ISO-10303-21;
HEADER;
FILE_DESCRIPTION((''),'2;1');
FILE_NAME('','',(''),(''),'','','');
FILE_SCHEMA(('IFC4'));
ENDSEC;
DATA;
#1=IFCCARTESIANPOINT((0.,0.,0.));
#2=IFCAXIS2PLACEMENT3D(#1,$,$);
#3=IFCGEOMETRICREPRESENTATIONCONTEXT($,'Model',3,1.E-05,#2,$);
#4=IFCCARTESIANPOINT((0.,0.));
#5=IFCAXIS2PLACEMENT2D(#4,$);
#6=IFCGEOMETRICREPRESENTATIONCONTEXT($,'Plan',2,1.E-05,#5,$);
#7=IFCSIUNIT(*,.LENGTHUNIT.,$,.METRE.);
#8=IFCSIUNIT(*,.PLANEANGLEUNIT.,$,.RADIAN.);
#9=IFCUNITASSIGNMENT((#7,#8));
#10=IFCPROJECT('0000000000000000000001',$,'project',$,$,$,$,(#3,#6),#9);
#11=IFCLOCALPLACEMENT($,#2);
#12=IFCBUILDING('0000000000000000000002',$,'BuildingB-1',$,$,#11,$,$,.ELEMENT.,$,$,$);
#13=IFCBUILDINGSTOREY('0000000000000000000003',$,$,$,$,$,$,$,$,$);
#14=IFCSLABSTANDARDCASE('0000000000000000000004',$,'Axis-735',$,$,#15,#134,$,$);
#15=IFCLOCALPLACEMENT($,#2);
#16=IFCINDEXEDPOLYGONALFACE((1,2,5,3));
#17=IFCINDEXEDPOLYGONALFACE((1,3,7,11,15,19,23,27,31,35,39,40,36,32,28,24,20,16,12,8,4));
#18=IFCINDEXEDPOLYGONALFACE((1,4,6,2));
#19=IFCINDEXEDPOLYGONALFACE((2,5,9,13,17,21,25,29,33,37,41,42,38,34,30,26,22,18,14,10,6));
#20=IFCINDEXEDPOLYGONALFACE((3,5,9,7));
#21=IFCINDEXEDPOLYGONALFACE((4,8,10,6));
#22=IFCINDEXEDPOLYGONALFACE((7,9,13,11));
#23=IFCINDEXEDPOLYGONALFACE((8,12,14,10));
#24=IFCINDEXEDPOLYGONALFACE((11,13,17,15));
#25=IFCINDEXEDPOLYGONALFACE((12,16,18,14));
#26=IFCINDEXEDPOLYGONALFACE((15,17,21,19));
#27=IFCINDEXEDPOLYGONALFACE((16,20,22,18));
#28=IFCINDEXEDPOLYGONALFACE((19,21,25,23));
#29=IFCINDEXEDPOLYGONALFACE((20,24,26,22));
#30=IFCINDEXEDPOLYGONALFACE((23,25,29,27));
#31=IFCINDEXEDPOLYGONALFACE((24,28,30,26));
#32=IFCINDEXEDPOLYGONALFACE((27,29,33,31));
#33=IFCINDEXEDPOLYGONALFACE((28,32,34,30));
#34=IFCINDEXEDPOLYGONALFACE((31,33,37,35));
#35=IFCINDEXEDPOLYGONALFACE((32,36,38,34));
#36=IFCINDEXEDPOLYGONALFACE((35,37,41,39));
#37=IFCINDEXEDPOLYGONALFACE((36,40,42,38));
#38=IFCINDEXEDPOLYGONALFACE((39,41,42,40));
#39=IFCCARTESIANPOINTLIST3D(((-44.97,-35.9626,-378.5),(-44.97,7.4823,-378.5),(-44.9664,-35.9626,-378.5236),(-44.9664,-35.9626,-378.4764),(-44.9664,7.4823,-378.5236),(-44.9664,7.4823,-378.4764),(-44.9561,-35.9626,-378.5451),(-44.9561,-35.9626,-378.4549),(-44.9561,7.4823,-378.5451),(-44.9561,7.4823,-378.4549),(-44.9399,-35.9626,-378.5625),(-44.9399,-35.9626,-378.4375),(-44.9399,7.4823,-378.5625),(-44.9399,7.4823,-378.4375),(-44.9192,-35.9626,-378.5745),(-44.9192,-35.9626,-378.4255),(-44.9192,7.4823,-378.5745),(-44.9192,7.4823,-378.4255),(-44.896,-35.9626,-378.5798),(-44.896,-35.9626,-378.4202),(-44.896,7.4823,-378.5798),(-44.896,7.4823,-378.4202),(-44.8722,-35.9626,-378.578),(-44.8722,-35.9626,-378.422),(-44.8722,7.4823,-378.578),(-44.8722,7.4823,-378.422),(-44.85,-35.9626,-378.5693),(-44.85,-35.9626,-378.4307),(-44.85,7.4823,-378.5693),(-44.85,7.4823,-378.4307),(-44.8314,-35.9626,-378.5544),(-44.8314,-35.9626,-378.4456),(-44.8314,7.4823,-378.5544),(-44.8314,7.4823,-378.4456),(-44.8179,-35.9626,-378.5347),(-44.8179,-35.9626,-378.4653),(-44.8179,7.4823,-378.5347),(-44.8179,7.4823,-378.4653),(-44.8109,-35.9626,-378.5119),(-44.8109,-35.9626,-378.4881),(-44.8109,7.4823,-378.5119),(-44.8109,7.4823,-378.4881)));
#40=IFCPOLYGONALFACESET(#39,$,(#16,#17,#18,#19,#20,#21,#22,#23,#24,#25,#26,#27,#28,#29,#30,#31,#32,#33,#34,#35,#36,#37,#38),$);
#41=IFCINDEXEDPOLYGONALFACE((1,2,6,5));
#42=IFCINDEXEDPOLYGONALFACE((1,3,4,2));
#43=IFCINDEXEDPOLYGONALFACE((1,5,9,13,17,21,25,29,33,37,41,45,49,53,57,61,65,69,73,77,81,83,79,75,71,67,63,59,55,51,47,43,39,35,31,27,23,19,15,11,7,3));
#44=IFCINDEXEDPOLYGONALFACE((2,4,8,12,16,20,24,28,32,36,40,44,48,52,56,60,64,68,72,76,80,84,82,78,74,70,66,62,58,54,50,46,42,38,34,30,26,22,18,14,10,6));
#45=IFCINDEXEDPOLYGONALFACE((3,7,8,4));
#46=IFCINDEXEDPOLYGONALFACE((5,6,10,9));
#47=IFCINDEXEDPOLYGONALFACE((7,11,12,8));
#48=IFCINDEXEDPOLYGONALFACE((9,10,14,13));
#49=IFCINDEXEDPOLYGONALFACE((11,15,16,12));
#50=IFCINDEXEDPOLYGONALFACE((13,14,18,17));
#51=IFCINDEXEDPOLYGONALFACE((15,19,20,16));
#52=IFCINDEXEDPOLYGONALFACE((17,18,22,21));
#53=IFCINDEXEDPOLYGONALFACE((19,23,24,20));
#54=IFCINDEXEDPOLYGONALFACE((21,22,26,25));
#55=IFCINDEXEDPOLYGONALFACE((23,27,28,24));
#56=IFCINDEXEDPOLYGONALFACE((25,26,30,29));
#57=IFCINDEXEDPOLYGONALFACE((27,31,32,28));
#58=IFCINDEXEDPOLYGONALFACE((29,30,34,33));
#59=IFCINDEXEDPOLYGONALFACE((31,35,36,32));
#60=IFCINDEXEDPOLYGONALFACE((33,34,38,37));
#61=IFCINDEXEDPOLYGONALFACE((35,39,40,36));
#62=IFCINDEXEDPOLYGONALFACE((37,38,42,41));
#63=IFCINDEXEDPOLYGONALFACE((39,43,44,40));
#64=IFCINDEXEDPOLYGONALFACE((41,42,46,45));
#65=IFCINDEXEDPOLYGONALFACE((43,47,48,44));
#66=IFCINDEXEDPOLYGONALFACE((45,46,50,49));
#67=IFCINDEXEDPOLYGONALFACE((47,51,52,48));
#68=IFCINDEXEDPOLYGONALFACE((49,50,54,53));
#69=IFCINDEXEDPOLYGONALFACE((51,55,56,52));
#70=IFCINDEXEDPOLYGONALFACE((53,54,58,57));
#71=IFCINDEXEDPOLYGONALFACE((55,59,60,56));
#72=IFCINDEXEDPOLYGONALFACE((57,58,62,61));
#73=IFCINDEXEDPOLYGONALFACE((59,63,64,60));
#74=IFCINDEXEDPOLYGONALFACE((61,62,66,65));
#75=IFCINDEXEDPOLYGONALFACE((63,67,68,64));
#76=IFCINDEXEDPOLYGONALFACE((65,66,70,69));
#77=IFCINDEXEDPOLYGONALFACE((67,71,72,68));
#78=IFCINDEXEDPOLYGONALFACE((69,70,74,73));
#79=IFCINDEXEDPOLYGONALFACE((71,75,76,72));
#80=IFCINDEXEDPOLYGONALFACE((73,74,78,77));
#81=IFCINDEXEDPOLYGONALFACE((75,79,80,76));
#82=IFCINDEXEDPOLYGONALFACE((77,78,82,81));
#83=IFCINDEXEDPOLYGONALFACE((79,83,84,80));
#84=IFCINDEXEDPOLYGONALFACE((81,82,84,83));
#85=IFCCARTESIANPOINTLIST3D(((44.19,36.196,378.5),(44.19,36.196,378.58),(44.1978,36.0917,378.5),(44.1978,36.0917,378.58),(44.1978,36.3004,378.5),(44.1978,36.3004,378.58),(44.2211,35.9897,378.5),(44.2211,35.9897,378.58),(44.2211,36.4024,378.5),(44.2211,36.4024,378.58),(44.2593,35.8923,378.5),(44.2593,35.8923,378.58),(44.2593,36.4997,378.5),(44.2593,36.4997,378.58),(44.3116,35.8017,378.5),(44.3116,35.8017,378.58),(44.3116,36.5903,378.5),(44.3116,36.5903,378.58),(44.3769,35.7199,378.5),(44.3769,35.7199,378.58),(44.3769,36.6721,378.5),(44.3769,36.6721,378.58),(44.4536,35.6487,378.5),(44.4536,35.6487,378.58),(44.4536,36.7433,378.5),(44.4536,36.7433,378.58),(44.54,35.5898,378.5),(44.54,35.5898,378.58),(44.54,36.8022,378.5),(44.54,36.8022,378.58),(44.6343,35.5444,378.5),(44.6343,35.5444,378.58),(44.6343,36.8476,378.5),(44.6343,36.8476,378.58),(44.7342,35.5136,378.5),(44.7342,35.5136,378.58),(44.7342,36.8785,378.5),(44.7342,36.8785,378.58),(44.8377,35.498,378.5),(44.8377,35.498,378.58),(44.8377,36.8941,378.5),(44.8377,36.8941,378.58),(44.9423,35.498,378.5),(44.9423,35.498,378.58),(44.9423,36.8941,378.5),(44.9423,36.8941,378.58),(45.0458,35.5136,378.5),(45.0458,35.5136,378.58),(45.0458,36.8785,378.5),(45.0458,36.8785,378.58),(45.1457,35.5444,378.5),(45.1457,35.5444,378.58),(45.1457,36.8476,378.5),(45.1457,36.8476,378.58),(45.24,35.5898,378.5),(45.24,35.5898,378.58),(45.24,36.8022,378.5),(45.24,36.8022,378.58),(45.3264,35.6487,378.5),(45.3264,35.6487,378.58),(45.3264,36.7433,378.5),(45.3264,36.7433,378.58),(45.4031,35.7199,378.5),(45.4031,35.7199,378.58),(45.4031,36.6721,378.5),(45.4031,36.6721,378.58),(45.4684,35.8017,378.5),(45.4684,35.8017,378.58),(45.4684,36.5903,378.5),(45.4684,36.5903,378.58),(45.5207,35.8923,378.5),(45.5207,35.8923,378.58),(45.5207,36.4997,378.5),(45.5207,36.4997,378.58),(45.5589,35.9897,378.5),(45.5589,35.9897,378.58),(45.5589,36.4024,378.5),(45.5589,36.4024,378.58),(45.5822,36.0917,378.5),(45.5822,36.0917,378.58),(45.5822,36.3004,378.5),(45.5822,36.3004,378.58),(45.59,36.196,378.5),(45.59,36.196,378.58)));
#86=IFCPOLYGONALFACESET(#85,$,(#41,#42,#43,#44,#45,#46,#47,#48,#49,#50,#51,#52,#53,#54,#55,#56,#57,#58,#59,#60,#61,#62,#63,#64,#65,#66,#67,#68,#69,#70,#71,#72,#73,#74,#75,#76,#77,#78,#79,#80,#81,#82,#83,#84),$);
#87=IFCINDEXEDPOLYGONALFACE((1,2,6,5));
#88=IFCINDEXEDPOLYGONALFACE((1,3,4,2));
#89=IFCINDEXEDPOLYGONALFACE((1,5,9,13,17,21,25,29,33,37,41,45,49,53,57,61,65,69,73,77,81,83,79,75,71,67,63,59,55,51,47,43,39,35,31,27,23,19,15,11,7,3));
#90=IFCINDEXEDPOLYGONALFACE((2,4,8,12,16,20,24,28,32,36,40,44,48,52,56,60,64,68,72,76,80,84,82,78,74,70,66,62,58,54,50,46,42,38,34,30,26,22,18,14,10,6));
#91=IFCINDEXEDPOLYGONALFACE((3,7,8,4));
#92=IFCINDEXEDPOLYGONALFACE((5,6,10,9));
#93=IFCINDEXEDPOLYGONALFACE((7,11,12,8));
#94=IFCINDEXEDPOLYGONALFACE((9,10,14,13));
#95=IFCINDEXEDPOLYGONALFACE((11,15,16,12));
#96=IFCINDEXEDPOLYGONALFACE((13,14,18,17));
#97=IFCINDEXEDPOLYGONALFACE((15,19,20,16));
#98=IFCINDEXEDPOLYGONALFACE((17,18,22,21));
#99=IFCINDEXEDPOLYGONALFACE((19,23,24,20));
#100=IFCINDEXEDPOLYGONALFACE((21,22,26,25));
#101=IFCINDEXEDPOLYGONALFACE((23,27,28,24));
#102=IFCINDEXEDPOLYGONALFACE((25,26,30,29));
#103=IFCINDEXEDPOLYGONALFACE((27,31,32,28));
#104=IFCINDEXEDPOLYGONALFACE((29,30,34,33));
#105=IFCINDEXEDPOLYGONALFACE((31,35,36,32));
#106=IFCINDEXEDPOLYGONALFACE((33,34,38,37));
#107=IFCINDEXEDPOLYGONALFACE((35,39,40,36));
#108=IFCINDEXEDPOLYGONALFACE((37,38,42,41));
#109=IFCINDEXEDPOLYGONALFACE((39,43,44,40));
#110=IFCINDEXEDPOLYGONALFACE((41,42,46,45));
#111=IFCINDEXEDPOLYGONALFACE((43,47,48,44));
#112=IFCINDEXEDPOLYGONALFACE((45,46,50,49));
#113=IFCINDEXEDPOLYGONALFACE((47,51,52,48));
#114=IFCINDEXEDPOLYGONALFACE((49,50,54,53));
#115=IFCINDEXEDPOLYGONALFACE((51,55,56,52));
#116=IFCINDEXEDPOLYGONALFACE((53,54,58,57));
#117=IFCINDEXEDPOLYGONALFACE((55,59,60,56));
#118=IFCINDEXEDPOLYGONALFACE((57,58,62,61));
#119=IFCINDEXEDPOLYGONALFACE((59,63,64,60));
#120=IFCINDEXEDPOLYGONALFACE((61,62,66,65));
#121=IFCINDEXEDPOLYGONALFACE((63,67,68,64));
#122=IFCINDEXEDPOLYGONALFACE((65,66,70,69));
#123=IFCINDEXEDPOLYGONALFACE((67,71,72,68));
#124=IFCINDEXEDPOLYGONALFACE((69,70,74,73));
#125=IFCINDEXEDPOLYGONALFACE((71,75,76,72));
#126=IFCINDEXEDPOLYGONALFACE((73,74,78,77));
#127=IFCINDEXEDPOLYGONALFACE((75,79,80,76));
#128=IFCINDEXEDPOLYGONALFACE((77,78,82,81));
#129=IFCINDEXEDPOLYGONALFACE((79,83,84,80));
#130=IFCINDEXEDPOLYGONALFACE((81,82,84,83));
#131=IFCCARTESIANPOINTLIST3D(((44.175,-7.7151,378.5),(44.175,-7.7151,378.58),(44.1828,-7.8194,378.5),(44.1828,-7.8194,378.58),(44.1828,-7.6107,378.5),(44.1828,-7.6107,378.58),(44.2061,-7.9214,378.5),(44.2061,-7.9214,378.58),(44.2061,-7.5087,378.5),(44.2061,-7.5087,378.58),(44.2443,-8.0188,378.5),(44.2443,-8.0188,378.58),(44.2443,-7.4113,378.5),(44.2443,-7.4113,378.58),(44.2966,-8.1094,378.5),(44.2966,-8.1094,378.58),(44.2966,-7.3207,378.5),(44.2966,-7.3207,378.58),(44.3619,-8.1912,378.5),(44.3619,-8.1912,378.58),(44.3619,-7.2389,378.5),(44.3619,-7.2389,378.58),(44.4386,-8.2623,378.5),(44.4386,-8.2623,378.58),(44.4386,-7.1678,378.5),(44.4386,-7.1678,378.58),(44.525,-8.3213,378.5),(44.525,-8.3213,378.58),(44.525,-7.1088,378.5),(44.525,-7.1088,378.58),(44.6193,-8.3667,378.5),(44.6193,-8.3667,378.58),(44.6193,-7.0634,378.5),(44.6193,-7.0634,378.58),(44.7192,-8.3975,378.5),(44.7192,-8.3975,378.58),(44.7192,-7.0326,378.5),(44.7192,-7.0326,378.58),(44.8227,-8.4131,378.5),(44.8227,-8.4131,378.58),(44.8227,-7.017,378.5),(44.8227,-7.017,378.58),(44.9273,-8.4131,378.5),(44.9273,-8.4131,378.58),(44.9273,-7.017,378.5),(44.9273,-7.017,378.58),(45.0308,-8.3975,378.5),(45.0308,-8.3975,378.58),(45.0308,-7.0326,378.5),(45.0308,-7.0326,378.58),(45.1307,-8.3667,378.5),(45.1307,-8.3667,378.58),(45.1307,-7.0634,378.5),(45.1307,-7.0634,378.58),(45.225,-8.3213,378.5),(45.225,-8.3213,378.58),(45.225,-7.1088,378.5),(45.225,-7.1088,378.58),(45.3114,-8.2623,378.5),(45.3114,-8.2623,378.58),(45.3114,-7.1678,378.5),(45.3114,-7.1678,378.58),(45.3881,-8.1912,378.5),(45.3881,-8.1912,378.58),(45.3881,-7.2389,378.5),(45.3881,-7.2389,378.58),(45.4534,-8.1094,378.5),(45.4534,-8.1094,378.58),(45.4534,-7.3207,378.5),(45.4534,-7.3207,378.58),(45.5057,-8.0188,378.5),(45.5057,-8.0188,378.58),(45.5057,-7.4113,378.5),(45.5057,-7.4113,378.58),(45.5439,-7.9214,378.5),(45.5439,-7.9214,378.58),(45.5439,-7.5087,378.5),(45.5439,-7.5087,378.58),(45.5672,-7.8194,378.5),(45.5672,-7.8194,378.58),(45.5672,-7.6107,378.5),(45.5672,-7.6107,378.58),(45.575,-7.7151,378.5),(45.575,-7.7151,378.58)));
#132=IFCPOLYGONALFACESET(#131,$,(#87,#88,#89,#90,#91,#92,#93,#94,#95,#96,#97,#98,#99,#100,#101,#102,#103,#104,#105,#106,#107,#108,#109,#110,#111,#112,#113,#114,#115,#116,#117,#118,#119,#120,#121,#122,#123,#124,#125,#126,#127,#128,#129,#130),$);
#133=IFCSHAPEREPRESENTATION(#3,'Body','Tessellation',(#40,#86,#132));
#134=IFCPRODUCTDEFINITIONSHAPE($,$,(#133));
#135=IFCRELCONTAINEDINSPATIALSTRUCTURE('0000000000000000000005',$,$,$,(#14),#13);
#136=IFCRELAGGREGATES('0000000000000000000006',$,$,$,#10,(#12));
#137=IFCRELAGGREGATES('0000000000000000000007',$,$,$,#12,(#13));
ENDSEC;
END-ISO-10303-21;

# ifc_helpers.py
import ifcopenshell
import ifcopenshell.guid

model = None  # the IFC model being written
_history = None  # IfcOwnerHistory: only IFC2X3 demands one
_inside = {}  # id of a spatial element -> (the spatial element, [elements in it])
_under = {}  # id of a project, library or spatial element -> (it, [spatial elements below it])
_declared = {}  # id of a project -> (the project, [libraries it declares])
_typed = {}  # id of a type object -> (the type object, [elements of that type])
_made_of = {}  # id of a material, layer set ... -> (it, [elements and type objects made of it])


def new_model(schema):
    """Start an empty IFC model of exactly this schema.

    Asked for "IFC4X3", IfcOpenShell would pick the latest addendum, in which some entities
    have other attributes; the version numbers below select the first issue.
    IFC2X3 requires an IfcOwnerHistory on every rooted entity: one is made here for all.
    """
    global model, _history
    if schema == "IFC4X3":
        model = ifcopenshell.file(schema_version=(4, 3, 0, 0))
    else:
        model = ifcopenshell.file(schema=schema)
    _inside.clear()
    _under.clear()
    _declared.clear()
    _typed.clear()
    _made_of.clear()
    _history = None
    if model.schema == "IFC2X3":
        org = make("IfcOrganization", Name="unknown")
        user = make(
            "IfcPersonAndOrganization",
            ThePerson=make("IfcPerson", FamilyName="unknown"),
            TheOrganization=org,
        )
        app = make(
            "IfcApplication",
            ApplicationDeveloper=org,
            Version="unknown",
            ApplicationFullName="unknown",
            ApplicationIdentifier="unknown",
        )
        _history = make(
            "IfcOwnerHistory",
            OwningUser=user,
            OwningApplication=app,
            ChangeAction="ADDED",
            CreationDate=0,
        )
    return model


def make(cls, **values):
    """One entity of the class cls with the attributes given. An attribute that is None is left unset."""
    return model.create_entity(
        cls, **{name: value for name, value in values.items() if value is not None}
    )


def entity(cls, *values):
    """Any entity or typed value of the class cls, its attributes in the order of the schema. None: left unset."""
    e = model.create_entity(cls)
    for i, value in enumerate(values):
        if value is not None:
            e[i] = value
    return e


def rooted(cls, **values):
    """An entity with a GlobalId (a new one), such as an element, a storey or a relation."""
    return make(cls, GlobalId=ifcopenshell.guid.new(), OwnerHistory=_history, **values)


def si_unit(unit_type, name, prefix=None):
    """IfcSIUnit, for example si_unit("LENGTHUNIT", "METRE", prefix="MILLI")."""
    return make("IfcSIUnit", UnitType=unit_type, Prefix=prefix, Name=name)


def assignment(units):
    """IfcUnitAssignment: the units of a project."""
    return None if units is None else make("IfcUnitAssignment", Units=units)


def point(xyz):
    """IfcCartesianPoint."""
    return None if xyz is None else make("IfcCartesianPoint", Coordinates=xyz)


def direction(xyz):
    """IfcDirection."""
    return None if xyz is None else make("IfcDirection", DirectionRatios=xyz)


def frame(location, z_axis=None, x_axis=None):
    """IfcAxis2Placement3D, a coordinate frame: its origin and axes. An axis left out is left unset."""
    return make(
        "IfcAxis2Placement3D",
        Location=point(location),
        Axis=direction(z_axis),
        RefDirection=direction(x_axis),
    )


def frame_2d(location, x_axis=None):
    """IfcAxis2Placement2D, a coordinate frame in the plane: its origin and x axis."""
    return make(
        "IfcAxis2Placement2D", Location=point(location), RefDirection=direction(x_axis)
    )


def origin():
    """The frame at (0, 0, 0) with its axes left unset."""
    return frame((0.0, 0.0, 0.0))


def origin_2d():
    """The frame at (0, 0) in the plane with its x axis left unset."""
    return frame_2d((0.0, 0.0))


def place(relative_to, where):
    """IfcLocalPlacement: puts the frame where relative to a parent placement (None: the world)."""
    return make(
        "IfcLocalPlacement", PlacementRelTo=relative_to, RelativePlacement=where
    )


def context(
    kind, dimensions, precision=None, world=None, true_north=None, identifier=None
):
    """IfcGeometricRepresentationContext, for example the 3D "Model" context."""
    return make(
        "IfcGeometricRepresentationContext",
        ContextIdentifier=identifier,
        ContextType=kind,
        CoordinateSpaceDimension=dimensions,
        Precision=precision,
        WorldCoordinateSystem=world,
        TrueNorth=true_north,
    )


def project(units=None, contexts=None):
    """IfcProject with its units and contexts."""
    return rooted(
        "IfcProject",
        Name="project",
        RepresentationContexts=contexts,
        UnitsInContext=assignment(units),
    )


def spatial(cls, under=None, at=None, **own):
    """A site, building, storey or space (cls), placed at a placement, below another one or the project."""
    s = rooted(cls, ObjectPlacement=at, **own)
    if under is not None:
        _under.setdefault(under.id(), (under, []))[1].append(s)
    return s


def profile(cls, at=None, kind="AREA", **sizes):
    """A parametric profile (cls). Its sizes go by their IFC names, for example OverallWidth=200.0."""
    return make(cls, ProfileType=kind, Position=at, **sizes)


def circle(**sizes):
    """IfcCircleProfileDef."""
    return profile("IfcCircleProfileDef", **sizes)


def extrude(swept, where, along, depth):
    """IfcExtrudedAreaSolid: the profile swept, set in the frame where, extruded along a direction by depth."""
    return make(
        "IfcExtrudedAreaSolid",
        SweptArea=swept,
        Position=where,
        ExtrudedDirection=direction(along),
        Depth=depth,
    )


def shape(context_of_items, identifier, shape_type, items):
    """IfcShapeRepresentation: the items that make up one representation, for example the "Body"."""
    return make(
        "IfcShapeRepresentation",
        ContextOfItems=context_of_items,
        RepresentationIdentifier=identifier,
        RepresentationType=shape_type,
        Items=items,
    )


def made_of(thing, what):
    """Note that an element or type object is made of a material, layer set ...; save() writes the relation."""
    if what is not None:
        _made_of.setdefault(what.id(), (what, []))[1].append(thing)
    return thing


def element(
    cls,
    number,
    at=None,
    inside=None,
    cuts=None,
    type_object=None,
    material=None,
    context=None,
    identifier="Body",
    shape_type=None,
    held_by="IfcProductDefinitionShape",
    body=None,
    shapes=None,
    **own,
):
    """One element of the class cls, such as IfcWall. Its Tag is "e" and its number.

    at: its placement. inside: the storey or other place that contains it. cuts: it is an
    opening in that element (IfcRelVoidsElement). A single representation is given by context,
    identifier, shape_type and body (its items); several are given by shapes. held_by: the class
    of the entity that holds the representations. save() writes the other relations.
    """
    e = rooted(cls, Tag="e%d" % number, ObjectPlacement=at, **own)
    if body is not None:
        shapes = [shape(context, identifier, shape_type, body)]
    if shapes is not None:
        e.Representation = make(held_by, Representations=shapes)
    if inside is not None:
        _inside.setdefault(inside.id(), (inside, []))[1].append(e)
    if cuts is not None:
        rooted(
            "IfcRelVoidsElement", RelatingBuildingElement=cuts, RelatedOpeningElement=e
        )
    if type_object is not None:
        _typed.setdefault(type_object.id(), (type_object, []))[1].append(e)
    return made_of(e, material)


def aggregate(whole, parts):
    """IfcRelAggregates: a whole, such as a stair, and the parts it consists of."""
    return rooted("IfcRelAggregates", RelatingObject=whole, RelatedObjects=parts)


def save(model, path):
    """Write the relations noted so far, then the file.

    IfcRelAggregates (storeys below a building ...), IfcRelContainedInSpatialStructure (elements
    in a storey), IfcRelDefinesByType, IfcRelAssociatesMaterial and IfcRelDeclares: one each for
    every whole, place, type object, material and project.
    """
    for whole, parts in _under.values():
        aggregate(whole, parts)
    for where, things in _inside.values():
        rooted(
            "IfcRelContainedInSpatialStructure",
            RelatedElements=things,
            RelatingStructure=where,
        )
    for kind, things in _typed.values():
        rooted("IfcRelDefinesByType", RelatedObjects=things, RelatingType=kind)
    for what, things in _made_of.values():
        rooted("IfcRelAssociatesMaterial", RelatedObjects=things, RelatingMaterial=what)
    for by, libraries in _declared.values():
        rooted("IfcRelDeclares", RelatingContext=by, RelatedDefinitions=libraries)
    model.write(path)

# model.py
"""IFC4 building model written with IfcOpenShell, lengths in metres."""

from ifc_helpers import new_model, entity, si_unit, frame, origin, origin_2d, place, context, project, spatial, circle, extrude, element, save


model = new_model("IFC4")

# Units and contexts
model_context = context("Model", 3, precision=1e-05, world=origin())
plan_context = context("Plan", 2, precision=1e-05, world=origin_2d())
ifc_project = project(units=[si_unit("LENGTHUNIT", "METRE"), si_unit("PLANEANGLEUNIT", "RADIAN")], contexts=[model_context, plan_context])

# Building, storey
building_placement = place(None, origin())
building = spatial("IfcBuilding", under=ifc_project, at=building_placement, Name="BuildingB-1", CompositionType="ELEMENT")
storey = spatial("IfcBuildingStorey", under=building)

# Slab
element("IfcSlabStandardCase", 1, inside=storey, Name="Axis-735", context=model_context, shape_type="AdvancedSweptSolid", body=[
    entity("IfcSurfaceCurveSweptAreaSolid", entity("IfcCircleProfileDef", "AREA", None, None, 0.08), None, entity("IfcPolyline", [entity("IfcCartesianPoint", [44.89, 35.9626, 378.5]), entity("IfcCartesianPoint", [44.89, -7.4823, 378.5])]), None, None, entity("IfcPlane", entity("IfcAxis2Placement3D", entity("IfcCartesianPoint", [44.89, 35.9626, 378.5]), entity("IfcDirection", [0.0, 0.0, 1.0]), entity("IfcDirection", [1.0, 0.0, 0.0])))),
    extrude(circle(Radius=0.7), frame((44.89, 36.196, 378.5)), (0.0, 0.0, 1.0), 0.08),
    extrude(circle(Radius=0.7), frame((44.875, -7.7151, 378.5)), (0.0, 0.0, 1.0), 0.08),
])

save(model, "model.ifc")
